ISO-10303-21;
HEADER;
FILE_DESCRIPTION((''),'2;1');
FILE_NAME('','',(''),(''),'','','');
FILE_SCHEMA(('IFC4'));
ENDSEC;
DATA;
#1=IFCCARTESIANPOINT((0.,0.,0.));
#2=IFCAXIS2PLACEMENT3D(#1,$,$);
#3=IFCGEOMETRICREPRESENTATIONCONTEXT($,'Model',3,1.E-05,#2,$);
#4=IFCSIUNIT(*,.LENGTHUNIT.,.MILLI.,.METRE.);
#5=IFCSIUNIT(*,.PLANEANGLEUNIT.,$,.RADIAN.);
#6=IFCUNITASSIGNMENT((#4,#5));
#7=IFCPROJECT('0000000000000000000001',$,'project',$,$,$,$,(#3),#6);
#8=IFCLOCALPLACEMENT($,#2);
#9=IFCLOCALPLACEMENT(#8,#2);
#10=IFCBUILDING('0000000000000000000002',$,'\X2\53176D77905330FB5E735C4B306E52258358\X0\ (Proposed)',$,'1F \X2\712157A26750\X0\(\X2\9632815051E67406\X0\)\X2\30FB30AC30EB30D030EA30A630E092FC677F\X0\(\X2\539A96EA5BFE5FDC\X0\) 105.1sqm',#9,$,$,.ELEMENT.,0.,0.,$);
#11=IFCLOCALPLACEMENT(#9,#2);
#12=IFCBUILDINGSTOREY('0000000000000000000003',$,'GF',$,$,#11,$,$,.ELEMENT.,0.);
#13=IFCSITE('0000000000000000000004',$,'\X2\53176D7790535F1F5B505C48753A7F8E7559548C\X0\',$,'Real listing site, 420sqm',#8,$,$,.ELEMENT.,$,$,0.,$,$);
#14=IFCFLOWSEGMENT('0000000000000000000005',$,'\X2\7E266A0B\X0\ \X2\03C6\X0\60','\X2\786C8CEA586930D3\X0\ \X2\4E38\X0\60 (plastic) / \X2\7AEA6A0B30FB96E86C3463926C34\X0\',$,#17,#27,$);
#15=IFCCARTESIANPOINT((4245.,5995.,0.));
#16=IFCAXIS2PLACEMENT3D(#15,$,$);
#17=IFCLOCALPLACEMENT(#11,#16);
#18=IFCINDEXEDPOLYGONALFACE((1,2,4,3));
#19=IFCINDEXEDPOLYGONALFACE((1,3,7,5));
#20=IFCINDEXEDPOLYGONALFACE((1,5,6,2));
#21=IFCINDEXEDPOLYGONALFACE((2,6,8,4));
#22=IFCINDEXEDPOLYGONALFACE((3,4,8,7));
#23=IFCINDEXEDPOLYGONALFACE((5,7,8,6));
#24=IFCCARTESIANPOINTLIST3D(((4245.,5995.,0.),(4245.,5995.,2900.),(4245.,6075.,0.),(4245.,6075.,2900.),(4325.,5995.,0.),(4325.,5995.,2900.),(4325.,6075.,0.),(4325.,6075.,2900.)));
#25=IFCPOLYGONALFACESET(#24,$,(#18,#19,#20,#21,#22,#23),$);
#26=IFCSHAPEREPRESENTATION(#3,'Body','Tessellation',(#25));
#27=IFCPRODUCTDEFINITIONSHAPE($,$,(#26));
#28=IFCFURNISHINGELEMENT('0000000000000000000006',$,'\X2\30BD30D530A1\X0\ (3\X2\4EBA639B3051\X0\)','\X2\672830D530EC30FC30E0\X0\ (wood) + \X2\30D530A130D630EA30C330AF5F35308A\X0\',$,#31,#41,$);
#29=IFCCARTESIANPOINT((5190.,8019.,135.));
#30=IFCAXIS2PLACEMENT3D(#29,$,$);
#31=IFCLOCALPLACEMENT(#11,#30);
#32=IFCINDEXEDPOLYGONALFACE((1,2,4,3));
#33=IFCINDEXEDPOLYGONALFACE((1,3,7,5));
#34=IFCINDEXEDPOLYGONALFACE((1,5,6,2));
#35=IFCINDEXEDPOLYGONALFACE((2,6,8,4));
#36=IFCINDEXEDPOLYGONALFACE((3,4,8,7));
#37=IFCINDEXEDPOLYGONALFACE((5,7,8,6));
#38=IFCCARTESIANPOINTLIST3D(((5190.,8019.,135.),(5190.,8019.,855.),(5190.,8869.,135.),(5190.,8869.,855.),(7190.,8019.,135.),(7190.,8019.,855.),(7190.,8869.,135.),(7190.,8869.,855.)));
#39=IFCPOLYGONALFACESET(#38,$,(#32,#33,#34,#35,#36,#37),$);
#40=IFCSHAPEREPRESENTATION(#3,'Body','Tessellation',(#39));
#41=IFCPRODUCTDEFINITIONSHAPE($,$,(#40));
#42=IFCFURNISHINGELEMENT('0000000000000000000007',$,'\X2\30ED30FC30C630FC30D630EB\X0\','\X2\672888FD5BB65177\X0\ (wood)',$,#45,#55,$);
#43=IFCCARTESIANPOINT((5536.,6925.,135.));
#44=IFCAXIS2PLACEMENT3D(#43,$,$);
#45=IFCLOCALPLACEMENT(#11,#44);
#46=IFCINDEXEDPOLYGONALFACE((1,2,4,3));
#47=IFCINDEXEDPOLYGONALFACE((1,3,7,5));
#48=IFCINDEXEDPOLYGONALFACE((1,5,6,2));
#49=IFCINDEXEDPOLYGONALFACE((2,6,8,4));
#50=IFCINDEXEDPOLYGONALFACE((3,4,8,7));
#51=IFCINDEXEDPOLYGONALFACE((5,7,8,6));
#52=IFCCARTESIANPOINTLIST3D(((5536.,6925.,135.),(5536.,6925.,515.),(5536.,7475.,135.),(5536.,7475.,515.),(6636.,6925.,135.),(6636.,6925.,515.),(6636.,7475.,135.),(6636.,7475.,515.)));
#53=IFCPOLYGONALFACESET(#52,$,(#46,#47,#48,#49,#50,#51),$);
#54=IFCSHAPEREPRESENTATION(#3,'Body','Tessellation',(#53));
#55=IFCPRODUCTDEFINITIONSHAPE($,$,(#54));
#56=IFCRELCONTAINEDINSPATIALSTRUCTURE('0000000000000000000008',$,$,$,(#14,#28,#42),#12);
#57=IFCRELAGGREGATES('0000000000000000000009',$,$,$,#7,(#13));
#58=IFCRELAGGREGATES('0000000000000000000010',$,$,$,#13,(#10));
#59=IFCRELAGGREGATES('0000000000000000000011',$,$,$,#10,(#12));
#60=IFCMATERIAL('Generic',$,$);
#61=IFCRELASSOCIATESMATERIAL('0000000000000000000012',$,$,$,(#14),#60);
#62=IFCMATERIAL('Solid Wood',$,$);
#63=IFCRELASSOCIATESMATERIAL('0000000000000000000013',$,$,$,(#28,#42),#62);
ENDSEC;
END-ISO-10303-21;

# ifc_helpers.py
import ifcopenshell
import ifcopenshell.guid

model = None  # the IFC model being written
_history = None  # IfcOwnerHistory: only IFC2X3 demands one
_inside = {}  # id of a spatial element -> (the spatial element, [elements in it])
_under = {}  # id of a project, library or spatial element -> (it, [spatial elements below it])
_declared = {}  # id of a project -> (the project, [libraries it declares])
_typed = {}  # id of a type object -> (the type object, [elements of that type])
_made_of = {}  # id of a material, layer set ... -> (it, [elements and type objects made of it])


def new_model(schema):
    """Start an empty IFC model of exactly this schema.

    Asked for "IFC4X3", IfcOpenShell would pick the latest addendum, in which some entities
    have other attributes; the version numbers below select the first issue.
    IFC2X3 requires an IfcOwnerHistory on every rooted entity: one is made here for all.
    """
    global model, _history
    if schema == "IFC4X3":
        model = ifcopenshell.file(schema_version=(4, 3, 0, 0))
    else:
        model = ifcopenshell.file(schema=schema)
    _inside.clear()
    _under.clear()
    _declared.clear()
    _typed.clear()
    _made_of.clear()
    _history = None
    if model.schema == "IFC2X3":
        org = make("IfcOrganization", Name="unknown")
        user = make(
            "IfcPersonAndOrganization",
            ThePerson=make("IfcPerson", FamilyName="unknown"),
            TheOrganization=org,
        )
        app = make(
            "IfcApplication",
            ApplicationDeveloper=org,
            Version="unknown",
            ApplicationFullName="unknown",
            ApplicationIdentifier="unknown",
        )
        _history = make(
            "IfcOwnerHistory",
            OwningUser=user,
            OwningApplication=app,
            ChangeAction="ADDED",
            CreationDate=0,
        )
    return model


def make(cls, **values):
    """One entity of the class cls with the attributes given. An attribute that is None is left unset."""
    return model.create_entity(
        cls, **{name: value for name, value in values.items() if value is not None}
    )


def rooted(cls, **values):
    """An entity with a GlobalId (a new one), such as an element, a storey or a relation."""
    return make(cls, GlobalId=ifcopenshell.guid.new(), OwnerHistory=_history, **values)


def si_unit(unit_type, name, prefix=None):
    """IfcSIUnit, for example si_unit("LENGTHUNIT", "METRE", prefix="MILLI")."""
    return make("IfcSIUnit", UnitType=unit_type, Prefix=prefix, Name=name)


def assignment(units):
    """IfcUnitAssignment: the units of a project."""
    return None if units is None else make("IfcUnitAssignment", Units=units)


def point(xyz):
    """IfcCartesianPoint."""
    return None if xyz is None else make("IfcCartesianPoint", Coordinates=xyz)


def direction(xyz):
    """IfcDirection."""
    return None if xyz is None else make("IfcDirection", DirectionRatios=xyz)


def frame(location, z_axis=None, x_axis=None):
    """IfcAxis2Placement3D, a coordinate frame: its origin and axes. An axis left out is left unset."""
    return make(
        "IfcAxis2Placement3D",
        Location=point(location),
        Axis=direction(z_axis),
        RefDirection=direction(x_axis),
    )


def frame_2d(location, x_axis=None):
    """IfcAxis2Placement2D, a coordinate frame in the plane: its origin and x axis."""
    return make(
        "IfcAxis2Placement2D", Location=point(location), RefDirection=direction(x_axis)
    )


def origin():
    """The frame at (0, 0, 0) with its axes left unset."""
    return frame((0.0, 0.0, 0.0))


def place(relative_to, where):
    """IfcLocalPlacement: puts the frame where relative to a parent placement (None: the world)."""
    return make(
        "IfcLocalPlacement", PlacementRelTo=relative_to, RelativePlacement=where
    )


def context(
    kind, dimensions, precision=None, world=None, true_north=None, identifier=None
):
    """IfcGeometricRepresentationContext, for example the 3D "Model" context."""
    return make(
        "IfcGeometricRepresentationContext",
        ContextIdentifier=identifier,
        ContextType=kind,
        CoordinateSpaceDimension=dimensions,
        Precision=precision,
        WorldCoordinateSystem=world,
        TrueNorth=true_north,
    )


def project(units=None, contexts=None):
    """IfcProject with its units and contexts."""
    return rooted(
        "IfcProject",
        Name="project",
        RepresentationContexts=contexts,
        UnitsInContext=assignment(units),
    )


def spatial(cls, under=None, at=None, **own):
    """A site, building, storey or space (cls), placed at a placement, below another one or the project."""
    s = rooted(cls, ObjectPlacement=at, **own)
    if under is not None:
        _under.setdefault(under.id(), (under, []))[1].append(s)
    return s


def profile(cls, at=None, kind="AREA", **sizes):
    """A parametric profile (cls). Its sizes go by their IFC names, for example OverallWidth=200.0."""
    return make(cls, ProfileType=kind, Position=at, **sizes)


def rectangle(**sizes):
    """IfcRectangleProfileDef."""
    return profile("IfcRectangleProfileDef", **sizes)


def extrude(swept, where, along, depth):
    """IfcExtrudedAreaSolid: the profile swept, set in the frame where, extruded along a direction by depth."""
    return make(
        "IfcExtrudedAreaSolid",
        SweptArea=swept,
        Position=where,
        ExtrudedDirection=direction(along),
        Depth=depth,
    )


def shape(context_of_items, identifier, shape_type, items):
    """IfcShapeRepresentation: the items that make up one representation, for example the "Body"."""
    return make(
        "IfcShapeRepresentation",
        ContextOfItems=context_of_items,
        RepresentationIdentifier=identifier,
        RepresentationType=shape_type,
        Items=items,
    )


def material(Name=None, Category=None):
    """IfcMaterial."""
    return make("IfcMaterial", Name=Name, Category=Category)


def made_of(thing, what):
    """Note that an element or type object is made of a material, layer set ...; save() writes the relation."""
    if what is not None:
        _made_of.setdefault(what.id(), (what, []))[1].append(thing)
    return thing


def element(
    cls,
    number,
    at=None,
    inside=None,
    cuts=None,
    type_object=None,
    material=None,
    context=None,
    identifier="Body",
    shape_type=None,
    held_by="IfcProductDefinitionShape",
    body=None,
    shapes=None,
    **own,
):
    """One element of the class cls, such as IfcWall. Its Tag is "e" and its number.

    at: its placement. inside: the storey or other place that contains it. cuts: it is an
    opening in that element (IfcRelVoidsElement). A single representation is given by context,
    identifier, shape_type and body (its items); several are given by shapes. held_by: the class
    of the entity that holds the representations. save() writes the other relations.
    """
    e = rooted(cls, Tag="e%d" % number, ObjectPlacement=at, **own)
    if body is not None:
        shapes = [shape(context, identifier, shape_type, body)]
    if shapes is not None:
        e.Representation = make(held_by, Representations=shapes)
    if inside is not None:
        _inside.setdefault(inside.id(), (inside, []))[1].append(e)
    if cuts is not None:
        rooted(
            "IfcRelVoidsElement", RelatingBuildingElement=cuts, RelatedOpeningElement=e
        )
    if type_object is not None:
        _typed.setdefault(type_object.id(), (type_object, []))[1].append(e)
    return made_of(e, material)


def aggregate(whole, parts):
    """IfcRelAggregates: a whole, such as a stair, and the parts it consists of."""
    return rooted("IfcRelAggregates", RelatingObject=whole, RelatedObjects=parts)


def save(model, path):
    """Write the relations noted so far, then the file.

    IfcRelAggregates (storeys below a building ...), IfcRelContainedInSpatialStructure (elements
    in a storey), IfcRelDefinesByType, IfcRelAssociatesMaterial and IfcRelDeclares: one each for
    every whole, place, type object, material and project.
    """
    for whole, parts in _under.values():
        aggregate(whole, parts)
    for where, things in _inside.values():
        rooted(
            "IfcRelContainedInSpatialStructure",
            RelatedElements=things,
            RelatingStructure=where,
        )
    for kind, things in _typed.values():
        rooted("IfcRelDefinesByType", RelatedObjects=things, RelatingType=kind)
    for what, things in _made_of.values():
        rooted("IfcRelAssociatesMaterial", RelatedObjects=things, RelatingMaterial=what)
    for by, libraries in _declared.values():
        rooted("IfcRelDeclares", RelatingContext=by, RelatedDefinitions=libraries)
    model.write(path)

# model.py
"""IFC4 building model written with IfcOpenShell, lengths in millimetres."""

from ifc_helpers import new_model, si_unit, frame, frame_2d, origin, place, context, project, spatial, rectangle, extrude, material, element, save


model = new_model("IFC4")

# Units and contexts
model_context = context("Model", 3, precision=1e-05, world=origin())
ifc_project = project(units=[si_unit("LENGTHUNIT", "METRE", prefix="MILLI"), si_unit("PLANEANGLEUNIT", "RADIAN")], contexts=[model_context])

# Site, building, storey
site_placement = place(None, origin())
site = spatial("IfcSite", under=ifc_project, at=site_placement, Name="北海道弟子屈町美留和", ObjectType="Real listing site, 420sqm", CompositionType="ELEMENT", RefElevation=0.0)
building_placement = place(site_placement, origin())
building = spatial("IfcBuilding", under=site, at=building_placement, Name="北海道・平屋の別荘 (Proposed)", ObjectType="1F 無垢材(防腐処理)・ガルバリウム鋼板(厚雪対応) 105.1sqm", CompositionType="ELEMENT", ElevationOfRefHeight=0.0, ElevationOfTerrain=0.0)
storey_placement = place(building_placement, origin())
storey = spatial("IfcBuildingStorey", under=building, at=storey_placement, Name="GF", CompositionType="ELEMENT", Elevation=0.0)

# Shared definitions
ifc_material_1 = material(Name="Solid Wood")

# Shared definitions
ifc_material_2 = material(Name="Generic")

# Flow segment
flow_segment_1_placement = place(storey_placement, frame((4245.0, 5995.0, 0.0)))
element("IfcFlowSegment", 1, at=flow_segment_1_placement, inside=storey, material=ifc_material_2, Name="縦樋 φ60", Description="硬質塩ビ 丸60 (plastic) / 竪樋・雨水排水", context=model_context, shape_type="SweptSolid", body=[
    extrude(rectangle(XDim=80.0, YDim=80.0, at=frame_2d((40.0, 40.0))), frame((4245.0, 5995.0, 0.0)), (0.0, 0.0, 1.0), 2900.0),
])

# Furnishing elements
furnishing_1_placement = place(storey_placement, frame((5190.0, 8019.0, 135.0)))
element("IfcFurnishingElement", 2, at=furnishing_1_placement, inside=storey, material=ifc_material_1, Name="ソファ (3人掛け)", Description="木フレーム (wood) + ファブリック張り", context=model_context, shape_type="SweptSolid", body=[
    extrude(rectangle(XDim=2000.0, YDim=850.0, at=frame_2d((1000.0, 425.0))), frame((5190.0, 8019.0, 135.0)), (0.0, 0.0, 1.0), 720.0),
])
furnishing_2_placement = place(storey_placement, frame((5536.0, 6925.0, 135.0)))
element("IfcFurnishingElement", 3, at=furnishing_2_placement, inside=storey, material=ifc_material_1, Name="ローテーブル", Description="木製家具 (wood)", context=model_context, shape_type="SweptSolid", body=[
    extrude(rectangle(XDim=1100.0, YDim=550.0, at=frame_2d((550.0, 275.0))), frame((5536.0, 6925.0, 135.0)), (0.0, 0.0, 1.0), 380.0),
])

save(model, "model.ifc")
